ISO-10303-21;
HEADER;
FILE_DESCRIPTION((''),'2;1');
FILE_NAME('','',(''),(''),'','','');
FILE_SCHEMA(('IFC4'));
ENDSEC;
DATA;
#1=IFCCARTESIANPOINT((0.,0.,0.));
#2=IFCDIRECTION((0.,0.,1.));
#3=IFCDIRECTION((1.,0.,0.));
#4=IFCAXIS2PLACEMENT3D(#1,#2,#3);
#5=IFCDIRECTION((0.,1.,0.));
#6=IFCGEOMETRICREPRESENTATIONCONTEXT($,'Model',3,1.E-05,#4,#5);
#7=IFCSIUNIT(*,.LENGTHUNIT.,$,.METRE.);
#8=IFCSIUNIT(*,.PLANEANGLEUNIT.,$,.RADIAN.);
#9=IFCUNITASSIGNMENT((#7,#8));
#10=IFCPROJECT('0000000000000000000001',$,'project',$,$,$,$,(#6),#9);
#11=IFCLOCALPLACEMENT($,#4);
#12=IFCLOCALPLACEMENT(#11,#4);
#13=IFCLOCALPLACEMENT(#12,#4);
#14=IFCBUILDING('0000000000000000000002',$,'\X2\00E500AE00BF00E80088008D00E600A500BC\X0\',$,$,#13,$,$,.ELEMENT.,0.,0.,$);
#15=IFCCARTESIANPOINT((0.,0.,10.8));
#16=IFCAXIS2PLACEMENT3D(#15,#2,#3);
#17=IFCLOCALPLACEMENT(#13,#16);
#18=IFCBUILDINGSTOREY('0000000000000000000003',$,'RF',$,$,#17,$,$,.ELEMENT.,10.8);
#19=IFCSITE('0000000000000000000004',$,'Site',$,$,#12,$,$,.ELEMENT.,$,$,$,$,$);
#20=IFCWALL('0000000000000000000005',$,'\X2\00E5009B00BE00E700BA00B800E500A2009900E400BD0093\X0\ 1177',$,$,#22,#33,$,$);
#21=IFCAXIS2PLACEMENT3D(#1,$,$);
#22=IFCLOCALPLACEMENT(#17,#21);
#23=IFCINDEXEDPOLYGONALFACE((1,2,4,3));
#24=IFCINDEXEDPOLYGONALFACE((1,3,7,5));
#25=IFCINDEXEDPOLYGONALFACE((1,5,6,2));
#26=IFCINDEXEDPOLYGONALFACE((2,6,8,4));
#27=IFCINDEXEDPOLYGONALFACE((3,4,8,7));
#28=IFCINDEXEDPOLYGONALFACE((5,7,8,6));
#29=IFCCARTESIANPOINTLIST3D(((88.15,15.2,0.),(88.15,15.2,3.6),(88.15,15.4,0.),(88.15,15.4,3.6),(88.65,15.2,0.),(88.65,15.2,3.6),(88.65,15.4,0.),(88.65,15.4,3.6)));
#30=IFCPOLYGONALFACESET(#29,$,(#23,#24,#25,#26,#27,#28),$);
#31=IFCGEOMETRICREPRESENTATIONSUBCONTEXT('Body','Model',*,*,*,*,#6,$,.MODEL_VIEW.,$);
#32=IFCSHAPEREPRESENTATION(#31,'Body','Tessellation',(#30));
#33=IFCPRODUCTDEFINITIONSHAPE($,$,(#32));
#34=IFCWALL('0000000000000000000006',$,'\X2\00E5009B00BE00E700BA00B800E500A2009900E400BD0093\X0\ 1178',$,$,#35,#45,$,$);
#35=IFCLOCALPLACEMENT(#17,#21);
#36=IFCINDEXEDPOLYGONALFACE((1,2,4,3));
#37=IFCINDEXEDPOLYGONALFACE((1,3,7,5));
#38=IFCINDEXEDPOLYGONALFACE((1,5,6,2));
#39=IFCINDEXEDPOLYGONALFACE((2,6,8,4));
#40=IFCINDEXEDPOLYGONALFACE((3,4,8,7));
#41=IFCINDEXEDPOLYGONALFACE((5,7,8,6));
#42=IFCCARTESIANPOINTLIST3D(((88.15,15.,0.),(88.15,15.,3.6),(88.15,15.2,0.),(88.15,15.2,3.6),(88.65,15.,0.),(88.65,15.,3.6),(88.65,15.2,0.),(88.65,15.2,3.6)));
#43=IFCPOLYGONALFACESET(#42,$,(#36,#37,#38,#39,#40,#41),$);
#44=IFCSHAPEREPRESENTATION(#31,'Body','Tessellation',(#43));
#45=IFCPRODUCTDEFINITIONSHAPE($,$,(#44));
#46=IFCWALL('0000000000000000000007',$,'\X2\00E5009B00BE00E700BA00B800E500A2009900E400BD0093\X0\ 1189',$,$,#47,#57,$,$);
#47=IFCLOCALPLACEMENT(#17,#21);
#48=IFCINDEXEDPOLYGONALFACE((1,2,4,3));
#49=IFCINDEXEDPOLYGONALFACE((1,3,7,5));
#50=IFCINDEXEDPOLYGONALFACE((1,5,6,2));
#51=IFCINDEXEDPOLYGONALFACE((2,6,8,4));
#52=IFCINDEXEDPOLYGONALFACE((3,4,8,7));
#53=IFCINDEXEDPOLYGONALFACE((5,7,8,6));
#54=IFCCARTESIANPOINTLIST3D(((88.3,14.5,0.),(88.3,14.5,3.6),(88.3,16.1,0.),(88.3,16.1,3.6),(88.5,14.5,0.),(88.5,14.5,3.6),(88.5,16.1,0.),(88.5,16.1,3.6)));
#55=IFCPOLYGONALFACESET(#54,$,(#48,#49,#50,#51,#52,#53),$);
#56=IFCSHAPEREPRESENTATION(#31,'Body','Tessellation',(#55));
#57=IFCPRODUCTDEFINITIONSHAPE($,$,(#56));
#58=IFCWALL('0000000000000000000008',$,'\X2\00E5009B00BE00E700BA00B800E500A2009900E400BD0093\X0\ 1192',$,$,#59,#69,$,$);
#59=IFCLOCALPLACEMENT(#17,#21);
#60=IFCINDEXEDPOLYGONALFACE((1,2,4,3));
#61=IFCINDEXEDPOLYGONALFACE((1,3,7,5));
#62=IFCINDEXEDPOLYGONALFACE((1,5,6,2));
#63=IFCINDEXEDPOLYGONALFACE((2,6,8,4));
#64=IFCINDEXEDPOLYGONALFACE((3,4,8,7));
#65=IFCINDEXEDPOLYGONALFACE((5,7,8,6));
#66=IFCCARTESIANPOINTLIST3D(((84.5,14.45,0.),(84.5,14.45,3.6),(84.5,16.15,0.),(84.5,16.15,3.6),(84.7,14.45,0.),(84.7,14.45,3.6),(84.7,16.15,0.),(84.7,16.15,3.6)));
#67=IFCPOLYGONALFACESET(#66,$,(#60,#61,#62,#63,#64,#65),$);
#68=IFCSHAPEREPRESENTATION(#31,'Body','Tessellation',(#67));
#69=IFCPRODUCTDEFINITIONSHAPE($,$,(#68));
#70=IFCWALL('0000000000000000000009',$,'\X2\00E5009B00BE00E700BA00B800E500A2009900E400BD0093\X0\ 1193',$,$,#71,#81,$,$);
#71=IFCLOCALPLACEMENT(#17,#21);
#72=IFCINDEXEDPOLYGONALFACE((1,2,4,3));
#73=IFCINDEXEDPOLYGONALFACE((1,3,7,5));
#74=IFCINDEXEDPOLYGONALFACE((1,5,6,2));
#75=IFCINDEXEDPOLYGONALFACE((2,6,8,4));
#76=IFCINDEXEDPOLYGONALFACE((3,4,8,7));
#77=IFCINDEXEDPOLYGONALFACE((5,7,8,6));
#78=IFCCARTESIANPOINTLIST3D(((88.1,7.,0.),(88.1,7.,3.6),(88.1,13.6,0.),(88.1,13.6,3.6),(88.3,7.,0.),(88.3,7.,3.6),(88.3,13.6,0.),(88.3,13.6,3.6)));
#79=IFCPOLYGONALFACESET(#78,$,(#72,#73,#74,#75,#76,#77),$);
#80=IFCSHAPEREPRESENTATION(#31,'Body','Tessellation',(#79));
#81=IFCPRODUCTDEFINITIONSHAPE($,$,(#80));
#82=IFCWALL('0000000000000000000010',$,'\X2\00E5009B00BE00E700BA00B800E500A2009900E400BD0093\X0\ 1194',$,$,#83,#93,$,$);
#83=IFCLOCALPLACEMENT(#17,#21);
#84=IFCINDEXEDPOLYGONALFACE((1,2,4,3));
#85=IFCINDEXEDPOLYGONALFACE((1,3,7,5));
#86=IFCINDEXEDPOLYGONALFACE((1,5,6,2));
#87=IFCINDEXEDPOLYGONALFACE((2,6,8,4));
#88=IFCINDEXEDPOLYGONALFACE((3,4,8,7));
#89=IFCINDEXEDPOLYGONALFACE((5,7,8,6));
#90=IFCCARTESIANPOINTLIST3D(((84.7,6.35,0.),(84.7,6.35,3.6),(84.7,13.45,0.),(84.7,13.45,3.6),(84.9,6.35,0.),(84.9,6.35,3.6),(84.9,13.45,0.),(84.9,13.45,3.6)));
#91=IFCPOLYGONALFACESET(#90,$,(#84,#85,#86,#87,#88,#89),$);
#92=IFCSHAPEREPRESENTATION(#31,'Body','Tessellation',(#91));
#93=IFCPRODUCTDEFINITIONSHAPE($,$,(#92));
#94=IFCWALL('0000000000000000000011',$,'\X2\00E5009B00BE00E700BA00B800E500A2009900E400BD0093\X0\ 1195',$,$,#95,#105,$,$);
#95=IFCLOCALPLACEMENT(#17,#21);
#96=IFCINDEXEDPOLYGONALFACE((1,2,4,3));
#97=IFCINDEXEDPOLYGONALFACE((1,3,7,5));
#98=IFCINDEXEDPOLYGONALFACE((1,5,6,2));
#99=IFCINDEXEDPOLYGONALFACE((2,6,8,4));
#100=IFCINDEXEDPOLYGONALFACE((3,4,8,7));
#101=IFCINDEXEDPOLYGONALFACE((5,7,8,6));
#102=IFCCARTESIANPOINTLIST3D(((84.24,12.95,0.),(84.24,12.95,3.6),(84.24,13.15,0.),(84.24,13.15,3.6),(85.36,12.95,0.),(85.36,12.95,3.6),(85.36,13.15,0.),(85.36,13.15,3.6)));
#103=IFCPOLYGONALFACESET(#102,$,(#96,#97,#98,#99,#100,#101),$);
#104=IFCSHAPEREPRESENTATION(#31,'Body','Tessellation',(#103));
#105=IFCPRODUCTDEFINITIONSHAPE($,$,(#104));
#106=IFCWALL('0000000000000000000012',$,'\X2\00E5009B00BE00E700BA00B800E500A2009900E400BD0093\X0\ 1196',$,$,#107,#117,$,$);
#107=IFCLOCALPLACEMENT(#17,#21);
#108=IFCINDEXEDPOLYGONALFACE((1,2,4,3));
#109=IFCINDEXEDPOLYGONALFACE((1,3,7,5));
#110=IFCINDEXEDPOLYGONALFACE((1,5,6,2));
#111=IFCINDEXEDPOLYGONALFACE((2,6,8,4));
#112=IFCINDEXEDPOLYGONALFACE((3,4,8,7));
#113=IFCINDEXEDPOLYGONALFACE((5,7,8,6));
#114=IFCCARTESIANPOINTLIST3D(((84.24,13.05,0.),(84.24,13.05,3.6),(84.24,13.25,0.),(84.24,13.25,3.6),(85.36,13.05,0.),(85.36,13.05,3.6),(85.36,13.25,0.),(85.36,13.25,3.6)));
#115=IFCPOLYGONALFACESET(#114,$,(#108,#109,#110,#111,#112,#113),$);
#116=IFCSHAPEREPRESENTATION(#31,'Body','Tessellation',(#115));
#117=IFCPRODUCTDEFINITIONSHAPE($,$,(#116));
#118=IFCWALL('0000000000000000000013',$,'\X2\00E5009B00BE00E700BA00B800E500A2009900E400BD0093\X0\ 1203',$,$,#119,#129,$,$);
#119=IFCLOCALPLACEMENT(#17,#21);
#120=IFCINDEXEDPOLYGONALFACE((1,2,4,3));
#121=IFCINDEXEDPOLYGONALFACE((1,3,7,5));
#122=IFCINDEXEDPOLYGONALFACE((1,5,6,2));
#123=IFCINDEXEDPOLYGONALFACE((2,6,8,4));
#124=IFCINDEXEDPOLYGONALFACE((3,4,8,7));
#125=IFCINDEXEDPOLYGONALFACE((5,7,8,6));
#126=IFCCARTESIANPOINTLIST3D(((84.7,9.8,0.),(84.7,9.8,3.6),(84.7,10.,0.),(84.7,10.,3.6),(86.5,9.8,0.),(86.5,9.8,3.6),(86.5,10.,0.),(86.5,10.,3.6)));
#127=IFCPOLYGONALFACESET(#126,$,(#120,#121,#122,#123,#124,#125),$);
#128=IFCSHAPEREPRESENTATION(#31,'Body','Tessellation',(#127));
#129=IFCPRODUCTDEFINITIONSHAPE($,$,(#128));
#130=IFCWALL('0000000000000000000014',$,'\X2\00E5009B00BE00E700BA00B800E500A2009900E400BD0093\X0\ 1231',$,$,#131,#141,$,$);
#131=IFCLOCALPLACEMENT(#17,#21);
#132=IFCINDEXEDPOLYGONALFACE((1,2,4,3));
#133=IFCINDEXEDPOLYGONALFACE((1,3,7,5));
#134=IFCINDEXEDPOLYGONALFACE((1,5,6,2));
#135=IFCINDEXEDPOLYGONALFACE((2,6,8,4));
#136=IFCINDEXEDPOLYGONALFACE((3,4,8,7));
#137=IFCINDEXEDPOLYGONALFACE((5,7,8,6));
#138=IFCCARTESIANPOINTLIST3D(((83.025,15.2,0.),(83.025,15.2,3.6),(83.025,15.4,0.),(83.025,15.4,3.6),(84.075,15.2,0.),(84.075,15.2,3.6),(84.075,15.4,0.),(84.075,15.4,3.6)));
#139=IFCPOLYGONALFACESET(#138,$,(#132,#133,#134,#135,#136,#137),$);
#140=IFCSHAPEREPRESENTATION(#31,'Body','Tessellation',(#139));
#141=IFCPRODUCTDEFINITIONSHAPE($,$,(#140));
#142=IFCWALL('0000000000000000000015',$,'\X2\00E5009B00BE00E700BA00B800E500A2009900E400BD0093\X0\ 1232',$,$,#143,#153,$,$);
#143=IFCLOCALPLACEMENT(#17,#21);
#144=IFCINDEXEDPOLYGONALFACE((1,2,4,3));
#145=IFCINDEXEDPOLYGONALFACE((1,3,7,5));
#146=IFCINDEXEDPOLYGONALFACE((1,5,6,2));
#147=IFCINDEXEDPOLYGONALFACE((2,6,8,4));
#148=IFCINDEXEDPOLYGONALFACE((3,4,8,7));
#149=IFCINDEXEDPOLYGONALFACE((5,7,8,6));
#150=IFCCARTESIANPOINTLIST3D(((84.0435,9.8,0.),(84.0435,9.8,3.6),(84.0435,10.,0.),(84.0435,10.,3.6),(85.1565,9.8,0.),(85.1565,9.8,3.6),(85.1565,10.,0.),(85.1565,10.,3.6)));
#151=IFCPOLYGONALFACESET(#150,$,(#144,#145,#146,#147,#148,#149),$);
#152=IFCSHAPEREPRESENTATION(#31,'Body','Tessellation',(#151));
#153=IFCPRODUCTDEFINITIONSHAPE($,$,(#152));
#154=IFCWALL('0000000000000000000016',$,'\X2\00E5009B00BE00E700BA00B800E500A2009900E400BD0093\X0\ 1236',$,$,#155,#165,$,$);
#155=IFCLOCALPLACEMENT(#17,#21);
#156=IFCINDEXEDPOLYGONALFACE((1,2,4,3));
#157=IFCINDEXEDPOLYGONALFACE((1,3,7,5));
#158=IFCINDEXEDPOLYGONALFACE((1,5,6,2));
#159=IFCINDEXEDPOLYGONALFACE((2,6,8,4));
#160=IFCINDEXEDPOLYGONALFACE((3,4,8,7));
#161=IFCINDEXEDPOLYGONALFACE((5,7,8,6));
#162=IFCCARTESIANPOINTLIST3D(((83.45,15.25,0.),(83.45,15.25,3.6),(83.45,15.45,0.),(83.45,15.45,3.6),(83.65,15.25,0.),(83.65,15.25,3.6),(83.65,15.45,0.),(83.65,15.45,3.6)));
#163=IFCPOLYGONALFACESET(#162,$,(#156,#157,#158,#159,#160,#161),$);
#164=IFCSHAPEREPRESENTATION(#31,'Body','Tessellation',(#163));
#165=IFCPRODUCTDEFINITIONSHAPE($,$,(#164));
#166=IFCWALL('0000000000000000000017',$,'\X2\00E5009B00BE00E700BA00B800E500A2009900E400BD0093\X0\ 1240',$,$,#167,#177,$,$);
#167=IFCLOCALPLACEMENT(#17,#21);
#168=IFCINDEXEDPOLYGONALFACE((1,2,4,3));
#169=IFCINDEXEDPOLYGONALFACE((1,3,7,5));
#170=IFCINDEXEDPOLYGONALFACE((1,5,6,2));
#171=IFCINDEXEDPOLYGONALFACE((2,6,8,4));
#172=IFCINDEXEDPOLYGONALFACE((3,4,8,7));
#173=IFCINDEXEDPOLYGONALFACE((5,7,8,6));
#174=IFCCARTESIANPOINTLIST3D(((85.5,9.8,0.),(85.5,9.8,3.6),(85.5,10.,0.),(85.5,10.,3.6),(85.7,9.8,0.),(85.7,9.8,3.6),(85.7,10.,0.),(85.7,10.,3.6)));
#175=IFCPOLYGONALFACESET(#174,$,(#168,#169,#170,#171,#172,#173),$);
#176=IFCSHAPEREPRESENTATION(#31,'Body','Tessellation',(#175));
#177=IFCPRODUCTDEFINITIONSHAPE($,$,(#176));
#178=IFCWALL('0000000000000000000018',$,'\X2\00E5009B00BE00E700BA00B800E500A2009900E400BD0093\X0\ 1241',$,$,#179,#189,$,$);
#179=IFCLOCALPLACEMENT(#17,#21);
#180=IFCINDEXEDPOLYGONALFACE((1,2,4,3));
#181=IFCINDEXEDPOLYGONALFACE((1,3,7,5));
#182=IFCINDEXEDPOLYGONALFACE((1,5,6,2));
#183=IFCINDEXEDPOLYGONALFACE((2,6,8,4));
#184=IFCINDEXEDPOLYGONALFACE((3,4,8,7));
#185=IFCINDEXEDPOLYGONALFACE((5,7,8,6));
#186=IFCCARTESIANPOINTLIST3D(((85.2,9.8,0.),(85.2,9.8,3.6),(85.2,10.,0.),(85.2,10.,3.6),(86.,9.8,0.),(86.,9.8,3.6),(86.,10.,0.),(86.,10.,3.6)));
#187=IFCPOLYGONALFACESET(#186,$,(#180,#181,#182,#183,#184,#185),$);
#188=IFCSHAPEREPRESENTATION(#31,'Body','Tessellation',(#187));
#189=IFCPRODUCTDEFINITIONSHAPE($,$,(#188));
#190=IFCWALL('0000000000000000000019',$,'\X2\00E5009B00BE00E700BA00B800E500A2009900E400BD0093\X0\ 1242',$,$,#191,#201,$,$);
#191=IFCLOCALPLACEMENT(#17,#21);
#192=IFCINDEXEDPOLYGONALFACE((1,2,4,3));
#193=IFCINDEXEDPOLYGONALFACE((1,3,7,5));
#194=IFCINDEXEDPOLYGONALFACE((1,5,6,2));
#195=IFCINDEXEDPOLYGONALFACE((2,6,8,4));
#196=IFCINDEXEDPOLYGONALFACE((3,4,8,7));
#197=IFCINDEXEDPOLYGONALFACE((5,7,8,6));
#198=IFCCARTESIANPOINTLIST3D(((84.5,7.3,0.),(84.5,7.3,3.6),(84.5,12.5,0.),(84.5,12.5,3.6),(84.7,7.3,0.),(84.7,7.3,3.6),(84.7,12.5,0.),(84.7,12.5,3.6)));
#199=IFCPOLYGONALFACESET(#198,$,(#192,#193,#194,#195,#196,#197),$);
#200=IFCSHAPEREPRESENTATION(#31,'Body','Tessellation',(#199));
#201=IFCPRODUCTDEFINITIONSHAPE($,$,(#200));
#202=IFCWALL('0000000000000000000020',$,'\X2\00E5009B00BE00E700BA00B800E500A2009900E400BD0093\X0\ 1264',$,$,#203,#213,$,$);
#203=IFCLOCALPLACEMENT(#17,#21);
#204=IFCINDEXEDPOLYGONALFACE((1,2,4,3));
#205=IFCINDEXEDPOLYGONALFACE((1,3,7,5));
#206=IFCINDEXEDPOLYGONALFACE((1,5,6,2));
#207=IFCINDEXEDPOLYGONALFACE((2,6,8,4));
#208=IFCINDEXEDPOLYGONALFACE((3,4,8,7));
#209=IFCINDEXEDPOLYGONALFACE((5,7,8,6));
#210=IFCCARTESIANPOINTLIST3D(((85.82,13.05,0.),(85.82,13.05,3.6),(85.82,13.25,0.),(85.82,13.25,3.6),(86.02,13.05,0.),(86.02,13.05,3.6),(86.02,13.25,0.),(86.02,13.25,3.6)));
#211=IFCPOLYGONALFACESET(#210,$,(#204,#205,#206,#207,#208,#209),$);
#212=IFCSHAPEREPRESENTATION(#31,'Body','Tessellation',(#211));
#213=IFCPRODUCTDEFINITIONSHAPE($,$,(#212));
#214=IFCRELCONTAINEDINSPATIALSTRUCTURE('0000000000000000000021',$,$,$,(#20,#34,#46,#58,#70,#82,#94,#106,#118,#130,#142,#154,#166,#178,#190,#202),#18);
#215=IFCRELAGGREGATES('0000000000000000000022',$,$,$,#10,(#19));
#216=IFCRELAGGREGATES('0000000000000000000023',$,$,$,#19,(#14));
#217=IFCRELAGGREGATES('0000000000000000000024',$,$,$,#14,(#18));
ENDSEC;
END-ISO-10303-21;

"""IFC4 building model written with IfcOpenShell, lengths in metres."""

from ifc_helpers import new_model, si_unit, direction, frame, frame_2d, origin_with_axes, place, context, subcontext, project, spatial, rectangle, extrude, element, save


model = new_model("IFC4")

# Units and contexts
model_context = context("Model", 3, precision=1e-05, world=origin_with_axes(), true_north=direction((0.0, 1.0, 0.0)))
body_context = subcontext(model_context, "Body", "Model", "MODEL_VIEW")
ifc_project = project(units=[si_unit("LENGTHUNIT", "METRE"), si_unit("PLANEANGLEUNIT", "RADIAN")], contexts=[model_context])

# Site, building, storey
placement = place(None, origin_with_axes())
site_placement = place(placement, origin_with_axes())
site = spatial("IfcSite", under=ifc_project, at=site_placement, Name="Site", CompositionType="ELEMENT")
building_placement = place(site_placement, origin_with_axes())
building = spatial("IfcBuilding", under=site, at=building_placement, Name="å®¿è\u0088\u008dæ¥¼", CompositionType="ELEMENT", ElevationOfRefHeight=0.0, ElevationOfTerrain=0.0)
storey_placement = place(building_placement, frame((0.0, 0.0, 10.8), z_axis=(0.0, 0.0, 1.0), x_axis=(1.0, 0.0, 0.0)))
storey = spatial("IfcBuildingStorey", under=building, at=storey_placement, Name="RF", CompositionType="ELEMENT", Elevation=10.8)

# Walls
for number, where, z_axis, x_axis, name in (
    (1, (88.4, 15.3, 0.0), (0.0, 0.0, 1.0), (1.0, 0.0, 0.0), "å\u009b¾çº¸å¢\u0099ä½\u0093 1177"),
    (2, (88.4, 15.1, 0.0), (0.0, 0.0, 1.0), (1.0, 0.0, 0.0), "å\u009b¾çº¸å¢\u0099ä½\u0093 1178"),
):
    element("IfcWall", number, at=place(storey_placement, frame(where, z_axis=z_axis, x_axis=x_axis)), inside=storey, Name=name, context=body_context, shape_type="SweptSolid", body=[
        extrude(rectangle(XDim=0.5, YDim=0.2, at=frame_2d((0.0, 0.0), x_axis=(1.0, 0.0, 0.0))), frame((0.0, 0.0, 0.0), z_axis=(0.0, 0.0, 1.0)), (0.0, 0.0, 1.0), 3.6),
    ])
wall_1_placement = place(storey_placement, frame((88.4, 15.3, 0.0), z_axis=(0.0, 0.0, 1.0), x_axis=(0.0, 1.0, 0.0)))
element("IfcWall", 3, at=wall_1_placement, inside=storey, Name="å\u009b¾çº¸å¢\u0099ä½\u0093 1189", context=body_context, shape_type="SweptSolid", body=[
    extrude(rectangle(XDim=1.6, YDim=0.2, at=frame_2d((0.0, 0.0), x_axis=(1.0, 0.0, 0.0))), frame((0.0, 0.0, 0.0), z_axis=(0.0, 0.0, 1.0)), (0.0, 0.0, 1.0), 3.6),
])
wall_2_placement = place(storey_placement, frame((84.6, 15.3, 0.0), z_axis=(0.0, 0.0, 1.0), x_axis=(0.0, 1.0, 0.0)))
element("IfcWall", 4, at=wall_2_placement, inside=storey, Name="å\u009b¾çº¸å¢\u0099ä½\u0093 1192", context=body_context, shape_type="SweptSolid", body=[
    extrude(rectangle(XDim=1.7, YDim=0.2, at=frame_2d((0.0, 0.0), x_axis=(1.0, 0.0, 0.0))), frame((0.0, 0.0, 0.0), z_axis=(0.0, 0.0, 1.0)), (0.0, 0.0, 1.0), 3.6),
])
wall_3_placement = place(storey_placement, frame((88.2, 10.3, 0.0), z_axis=(0.0, 0.0, 1.0), x_axis=(0.0, 1.0, 0.0)))
element("IfcWall", 5, at=wall_3_placement, inside=storey, Name="å\u009b¾çº¸å¢\u0099ä½\u0093 1193", context=body_context, shape_type="SweptSolid", body=[
    extrude(rectangle(XDim=6.6, YDim=0.2, at=frame_2d((0.0, 0.0), x_axis=(1.0, 0.0, 0.0))), frame((0.0, 0.0, 0.0), z_axis=(0.0, 0.0, 1.0)), (0.0, 0.0, 1.0), 3.6),
])
wall_4_placement = place(storey_placement, frame((84.8, 9.9, 0.0), z_axis=(0.0, 0.0, 1.0), x_axis=(0.0, 1.0, 0.0)))
element("IfcWall", 6, at=wall_4_placement, inside=storey, Name="å\u009b¾çº¸å¢\u0099ä½\u0093 1194", context=body_context, shape_type="SweptSolid", body=[
    extrude(rectangle(XDim=7.1, YDim=0.2, at=frame_2d((0.0, 0.0), x_axis=(1.0, 0.0, 0.0))), frame((0.0, 0.0, 0.0), z_axis=(0.0, 0.0, 1.0)), (0.0, 0.0, 1.0), 3.6),
])
for number, where, z_axis, x_axis, name in (
    (7, (84.8, 13.05, 0.0), (0.0, 0.0, 1.0), (1.0, 0.0, 0.0), "å\u009b¾çº¸å¢\u0099ä½\u0093 1195"),
    (8, (84.8, 13.15, 0.0), (0.0, 0.0, 1.0), (1.0, 0.0, 0.0), "å\u009b¾çº¸å¢\u0099ä½\u0093 1196"),
):
    element("IfcWall", number, at=place(storey_placement, frame(where, z_axis=z_axis, x_axis=x_axis)), inside=storey, Name=name, context=body_context, shape_type="SweptSolid", body=[
        extrude(rectangle(XDim=1.12, YDim=0.2, at=frame_2d((0.0, 0.0), x_axis=(1.0, 0.0, 0.0))), frame((0.0, 0.0, 0.0), z_axis=(0.0, 0.0, 1.0)), (0.0, 0.0, 1.0), 3.6),
    ])
wall_5_placement = place(storey_placement, frame((85.6, 9.9, 0.0), z_axis=(0.0, 0.0, 1.0), x_axis=(1.0, 0.0, 0.0)))
element("IfcWall", 9, at=wall_5_placement, inside=storey, Name="å\u009b¾çº¸å¢\u0099ä½\u0093 1203", context=body_context, shape_type="SweptSolid", body=[
    extrude(rectangle(XDim=1.8, YDim=0.2, at=frame_2d((0.0, 0.0), x_axis=(1.0, 0.0, 0.0))), frame((0.0, 0.0, 0.0), z_axis=(0.0, 0.0, 1.0)), (0.0, 0.0, 1.0), 3.6),
])
wall_6_placement = place(storey_placement, frame((83.55, 15.3, 0.0), z_axis=(0.0, 0.0, 1.0), x_axis=(1.0, 0.0, 0.0)))
element("IfcWall", 10, at=wall_6_placement, inside=storey, Name="å\u009b¾çº¸å¢\u0099ä½\u0093 1231", context=body_context, shape_type="SweptSolid", body=[
    extrude(rectangle(XDim=1.05, YDim=0.2, at=frame_2d((0.0, 0.0), x_axis=(1.0, 0.0, 0.0))), frame((0.0, 0.0, 0.0), z_axis=(0.0, 0.0, 1.0)), (0.0, 0.0, 1.0), 3.6),
])
wall_7_placement = place(storey_placement, frame((84.6, 9.9, 0.0), z_axis=(0.0, 0.0, 1.0), x_axis=(-1.0, 0.0, 0.0)))
element("IfcWall", 11, at=wall_7_placement, inside=storey, Name="å\u009b¾çº¸å¢\u0099ä½\u0093 1232", context=body_context, shape_type="SweptSolid", body=[
    extrude(rectangle(XDim=1.113, YDim=0.2, at=frame_2d((0.0, 0.0), x_axis=(1.0, 0.0, 0.0))), frame((0.0, 0.0, 0.0), z_axis=(0.0, 0.0, 1.0)), (0.0, 0.0, 1.0), 3.6),
])
for number, where, z_axis, x_axis, name in (
    (12, (83.55, 15.35, 0.0), (0.0, 0.0, 1.0), (-1.0, 0.0, 0.0), "å\u009b¾çº¸å¢\u0099ä½\u0093 1236"),
    (13, (85.6, 9.9, 0.0), (0.0, 0.0, 1.0), (0.0, -1.0, 0.0), "å\u009b¾çº¸å¢\u0099ä½\u0093 1240"),
):
    element("IfcWall", number, at=place(storey_placement, frame(where, z_axis=z_axis, x_axis=x_axis)), inside=storey, Name=name, context=body_context, shape_type="SweptSolid", body=[
        extrude(rectangle(XDim=0.2, YDim=0.2, at=frame_2d((0.0, 0.0), x_axis=(1.0, 0.0, 0.0))), frame((0.0, 0.0, 0.0), z_axis=(0.0, 0.0, 1.0)), (0.0, 0.0, 1.0), 3.6),
    ])
wall_8_placement = place(storey_placement, frame((85.6, 9.9, 0.0), z_axis=(0.0, 0.0, 1.0), x_axis=(-1.0, 0.0, 0.0)))
element("IfcWall", 14, at=wall_8_placement, inside=storey, Name="å\u009b¾çº¸å¢\u0099ä½\u0093 1241", context=body_context, shape_type="SweptSolid", body=[
    extrude(rectangle(XDim=0.8, YDim=0.2, at=frame_2d((0.0, 0.0), x_axis=(1.0, 0.0, 0.0))), frame((0.0, 0.0, 0.0), z_axis=(0.0, 0.0, 1.0)), (0.0, 0.0, 1.0), 3.6),
])
wall_9_placement = place(storey_placement, frame((84.6, 9.9, 0.0), z_axis=(0.0, 0.0, 1.0), x_axis=(0.0, 1.0, 0.0)))
element("IfcWall", 15, at=wall_9_placement, inside=storey, Name="å\u009b¾çº¸å¢\u0099ä½\u0093 1242", context=body_context, shape_type="SweptSolid", body=[
    extrude(rectangle(XDim=5.2, YDim=0.2, at=frame_2d((0.0, 0.0), x_axis=(1.0, 0.0, 0.0))), frame((0.0, 0.0, 0.0), z_axis=(0.0, 0.0, 1.0)), (0.0, 0.0, 1.0), 3.6),
])
for number, where, z_axis, x_axis, name in (
    (16, (85.92, 13.15, 0.0), (0.0, 0.0, 1.0), (0.0, -1.0, 0.0), "å\u009b¾çº¸å¢\u0099ä½\u0093 1264"),
):
    element("IfcWall", number, at=place(storey_placement, frame(where, z_axis=z_axis, x_axis=x_axis)), inside=storey, Name=name, context=body_context, shape_type="SweptSolid", body=[
        extrude(rectangle(XDim=0.2, YDim=0.2, at=frame_2d((0.0, 0.0), x_axis=(1.0, 0.0, 0.0))), frame((0.0, 0.0, 0.0), z_axis=(0.0, 0.0, 1.0)), (0.0, 0.0, 1.0), 3.6),
    ])

save(model, "model.ifc")
